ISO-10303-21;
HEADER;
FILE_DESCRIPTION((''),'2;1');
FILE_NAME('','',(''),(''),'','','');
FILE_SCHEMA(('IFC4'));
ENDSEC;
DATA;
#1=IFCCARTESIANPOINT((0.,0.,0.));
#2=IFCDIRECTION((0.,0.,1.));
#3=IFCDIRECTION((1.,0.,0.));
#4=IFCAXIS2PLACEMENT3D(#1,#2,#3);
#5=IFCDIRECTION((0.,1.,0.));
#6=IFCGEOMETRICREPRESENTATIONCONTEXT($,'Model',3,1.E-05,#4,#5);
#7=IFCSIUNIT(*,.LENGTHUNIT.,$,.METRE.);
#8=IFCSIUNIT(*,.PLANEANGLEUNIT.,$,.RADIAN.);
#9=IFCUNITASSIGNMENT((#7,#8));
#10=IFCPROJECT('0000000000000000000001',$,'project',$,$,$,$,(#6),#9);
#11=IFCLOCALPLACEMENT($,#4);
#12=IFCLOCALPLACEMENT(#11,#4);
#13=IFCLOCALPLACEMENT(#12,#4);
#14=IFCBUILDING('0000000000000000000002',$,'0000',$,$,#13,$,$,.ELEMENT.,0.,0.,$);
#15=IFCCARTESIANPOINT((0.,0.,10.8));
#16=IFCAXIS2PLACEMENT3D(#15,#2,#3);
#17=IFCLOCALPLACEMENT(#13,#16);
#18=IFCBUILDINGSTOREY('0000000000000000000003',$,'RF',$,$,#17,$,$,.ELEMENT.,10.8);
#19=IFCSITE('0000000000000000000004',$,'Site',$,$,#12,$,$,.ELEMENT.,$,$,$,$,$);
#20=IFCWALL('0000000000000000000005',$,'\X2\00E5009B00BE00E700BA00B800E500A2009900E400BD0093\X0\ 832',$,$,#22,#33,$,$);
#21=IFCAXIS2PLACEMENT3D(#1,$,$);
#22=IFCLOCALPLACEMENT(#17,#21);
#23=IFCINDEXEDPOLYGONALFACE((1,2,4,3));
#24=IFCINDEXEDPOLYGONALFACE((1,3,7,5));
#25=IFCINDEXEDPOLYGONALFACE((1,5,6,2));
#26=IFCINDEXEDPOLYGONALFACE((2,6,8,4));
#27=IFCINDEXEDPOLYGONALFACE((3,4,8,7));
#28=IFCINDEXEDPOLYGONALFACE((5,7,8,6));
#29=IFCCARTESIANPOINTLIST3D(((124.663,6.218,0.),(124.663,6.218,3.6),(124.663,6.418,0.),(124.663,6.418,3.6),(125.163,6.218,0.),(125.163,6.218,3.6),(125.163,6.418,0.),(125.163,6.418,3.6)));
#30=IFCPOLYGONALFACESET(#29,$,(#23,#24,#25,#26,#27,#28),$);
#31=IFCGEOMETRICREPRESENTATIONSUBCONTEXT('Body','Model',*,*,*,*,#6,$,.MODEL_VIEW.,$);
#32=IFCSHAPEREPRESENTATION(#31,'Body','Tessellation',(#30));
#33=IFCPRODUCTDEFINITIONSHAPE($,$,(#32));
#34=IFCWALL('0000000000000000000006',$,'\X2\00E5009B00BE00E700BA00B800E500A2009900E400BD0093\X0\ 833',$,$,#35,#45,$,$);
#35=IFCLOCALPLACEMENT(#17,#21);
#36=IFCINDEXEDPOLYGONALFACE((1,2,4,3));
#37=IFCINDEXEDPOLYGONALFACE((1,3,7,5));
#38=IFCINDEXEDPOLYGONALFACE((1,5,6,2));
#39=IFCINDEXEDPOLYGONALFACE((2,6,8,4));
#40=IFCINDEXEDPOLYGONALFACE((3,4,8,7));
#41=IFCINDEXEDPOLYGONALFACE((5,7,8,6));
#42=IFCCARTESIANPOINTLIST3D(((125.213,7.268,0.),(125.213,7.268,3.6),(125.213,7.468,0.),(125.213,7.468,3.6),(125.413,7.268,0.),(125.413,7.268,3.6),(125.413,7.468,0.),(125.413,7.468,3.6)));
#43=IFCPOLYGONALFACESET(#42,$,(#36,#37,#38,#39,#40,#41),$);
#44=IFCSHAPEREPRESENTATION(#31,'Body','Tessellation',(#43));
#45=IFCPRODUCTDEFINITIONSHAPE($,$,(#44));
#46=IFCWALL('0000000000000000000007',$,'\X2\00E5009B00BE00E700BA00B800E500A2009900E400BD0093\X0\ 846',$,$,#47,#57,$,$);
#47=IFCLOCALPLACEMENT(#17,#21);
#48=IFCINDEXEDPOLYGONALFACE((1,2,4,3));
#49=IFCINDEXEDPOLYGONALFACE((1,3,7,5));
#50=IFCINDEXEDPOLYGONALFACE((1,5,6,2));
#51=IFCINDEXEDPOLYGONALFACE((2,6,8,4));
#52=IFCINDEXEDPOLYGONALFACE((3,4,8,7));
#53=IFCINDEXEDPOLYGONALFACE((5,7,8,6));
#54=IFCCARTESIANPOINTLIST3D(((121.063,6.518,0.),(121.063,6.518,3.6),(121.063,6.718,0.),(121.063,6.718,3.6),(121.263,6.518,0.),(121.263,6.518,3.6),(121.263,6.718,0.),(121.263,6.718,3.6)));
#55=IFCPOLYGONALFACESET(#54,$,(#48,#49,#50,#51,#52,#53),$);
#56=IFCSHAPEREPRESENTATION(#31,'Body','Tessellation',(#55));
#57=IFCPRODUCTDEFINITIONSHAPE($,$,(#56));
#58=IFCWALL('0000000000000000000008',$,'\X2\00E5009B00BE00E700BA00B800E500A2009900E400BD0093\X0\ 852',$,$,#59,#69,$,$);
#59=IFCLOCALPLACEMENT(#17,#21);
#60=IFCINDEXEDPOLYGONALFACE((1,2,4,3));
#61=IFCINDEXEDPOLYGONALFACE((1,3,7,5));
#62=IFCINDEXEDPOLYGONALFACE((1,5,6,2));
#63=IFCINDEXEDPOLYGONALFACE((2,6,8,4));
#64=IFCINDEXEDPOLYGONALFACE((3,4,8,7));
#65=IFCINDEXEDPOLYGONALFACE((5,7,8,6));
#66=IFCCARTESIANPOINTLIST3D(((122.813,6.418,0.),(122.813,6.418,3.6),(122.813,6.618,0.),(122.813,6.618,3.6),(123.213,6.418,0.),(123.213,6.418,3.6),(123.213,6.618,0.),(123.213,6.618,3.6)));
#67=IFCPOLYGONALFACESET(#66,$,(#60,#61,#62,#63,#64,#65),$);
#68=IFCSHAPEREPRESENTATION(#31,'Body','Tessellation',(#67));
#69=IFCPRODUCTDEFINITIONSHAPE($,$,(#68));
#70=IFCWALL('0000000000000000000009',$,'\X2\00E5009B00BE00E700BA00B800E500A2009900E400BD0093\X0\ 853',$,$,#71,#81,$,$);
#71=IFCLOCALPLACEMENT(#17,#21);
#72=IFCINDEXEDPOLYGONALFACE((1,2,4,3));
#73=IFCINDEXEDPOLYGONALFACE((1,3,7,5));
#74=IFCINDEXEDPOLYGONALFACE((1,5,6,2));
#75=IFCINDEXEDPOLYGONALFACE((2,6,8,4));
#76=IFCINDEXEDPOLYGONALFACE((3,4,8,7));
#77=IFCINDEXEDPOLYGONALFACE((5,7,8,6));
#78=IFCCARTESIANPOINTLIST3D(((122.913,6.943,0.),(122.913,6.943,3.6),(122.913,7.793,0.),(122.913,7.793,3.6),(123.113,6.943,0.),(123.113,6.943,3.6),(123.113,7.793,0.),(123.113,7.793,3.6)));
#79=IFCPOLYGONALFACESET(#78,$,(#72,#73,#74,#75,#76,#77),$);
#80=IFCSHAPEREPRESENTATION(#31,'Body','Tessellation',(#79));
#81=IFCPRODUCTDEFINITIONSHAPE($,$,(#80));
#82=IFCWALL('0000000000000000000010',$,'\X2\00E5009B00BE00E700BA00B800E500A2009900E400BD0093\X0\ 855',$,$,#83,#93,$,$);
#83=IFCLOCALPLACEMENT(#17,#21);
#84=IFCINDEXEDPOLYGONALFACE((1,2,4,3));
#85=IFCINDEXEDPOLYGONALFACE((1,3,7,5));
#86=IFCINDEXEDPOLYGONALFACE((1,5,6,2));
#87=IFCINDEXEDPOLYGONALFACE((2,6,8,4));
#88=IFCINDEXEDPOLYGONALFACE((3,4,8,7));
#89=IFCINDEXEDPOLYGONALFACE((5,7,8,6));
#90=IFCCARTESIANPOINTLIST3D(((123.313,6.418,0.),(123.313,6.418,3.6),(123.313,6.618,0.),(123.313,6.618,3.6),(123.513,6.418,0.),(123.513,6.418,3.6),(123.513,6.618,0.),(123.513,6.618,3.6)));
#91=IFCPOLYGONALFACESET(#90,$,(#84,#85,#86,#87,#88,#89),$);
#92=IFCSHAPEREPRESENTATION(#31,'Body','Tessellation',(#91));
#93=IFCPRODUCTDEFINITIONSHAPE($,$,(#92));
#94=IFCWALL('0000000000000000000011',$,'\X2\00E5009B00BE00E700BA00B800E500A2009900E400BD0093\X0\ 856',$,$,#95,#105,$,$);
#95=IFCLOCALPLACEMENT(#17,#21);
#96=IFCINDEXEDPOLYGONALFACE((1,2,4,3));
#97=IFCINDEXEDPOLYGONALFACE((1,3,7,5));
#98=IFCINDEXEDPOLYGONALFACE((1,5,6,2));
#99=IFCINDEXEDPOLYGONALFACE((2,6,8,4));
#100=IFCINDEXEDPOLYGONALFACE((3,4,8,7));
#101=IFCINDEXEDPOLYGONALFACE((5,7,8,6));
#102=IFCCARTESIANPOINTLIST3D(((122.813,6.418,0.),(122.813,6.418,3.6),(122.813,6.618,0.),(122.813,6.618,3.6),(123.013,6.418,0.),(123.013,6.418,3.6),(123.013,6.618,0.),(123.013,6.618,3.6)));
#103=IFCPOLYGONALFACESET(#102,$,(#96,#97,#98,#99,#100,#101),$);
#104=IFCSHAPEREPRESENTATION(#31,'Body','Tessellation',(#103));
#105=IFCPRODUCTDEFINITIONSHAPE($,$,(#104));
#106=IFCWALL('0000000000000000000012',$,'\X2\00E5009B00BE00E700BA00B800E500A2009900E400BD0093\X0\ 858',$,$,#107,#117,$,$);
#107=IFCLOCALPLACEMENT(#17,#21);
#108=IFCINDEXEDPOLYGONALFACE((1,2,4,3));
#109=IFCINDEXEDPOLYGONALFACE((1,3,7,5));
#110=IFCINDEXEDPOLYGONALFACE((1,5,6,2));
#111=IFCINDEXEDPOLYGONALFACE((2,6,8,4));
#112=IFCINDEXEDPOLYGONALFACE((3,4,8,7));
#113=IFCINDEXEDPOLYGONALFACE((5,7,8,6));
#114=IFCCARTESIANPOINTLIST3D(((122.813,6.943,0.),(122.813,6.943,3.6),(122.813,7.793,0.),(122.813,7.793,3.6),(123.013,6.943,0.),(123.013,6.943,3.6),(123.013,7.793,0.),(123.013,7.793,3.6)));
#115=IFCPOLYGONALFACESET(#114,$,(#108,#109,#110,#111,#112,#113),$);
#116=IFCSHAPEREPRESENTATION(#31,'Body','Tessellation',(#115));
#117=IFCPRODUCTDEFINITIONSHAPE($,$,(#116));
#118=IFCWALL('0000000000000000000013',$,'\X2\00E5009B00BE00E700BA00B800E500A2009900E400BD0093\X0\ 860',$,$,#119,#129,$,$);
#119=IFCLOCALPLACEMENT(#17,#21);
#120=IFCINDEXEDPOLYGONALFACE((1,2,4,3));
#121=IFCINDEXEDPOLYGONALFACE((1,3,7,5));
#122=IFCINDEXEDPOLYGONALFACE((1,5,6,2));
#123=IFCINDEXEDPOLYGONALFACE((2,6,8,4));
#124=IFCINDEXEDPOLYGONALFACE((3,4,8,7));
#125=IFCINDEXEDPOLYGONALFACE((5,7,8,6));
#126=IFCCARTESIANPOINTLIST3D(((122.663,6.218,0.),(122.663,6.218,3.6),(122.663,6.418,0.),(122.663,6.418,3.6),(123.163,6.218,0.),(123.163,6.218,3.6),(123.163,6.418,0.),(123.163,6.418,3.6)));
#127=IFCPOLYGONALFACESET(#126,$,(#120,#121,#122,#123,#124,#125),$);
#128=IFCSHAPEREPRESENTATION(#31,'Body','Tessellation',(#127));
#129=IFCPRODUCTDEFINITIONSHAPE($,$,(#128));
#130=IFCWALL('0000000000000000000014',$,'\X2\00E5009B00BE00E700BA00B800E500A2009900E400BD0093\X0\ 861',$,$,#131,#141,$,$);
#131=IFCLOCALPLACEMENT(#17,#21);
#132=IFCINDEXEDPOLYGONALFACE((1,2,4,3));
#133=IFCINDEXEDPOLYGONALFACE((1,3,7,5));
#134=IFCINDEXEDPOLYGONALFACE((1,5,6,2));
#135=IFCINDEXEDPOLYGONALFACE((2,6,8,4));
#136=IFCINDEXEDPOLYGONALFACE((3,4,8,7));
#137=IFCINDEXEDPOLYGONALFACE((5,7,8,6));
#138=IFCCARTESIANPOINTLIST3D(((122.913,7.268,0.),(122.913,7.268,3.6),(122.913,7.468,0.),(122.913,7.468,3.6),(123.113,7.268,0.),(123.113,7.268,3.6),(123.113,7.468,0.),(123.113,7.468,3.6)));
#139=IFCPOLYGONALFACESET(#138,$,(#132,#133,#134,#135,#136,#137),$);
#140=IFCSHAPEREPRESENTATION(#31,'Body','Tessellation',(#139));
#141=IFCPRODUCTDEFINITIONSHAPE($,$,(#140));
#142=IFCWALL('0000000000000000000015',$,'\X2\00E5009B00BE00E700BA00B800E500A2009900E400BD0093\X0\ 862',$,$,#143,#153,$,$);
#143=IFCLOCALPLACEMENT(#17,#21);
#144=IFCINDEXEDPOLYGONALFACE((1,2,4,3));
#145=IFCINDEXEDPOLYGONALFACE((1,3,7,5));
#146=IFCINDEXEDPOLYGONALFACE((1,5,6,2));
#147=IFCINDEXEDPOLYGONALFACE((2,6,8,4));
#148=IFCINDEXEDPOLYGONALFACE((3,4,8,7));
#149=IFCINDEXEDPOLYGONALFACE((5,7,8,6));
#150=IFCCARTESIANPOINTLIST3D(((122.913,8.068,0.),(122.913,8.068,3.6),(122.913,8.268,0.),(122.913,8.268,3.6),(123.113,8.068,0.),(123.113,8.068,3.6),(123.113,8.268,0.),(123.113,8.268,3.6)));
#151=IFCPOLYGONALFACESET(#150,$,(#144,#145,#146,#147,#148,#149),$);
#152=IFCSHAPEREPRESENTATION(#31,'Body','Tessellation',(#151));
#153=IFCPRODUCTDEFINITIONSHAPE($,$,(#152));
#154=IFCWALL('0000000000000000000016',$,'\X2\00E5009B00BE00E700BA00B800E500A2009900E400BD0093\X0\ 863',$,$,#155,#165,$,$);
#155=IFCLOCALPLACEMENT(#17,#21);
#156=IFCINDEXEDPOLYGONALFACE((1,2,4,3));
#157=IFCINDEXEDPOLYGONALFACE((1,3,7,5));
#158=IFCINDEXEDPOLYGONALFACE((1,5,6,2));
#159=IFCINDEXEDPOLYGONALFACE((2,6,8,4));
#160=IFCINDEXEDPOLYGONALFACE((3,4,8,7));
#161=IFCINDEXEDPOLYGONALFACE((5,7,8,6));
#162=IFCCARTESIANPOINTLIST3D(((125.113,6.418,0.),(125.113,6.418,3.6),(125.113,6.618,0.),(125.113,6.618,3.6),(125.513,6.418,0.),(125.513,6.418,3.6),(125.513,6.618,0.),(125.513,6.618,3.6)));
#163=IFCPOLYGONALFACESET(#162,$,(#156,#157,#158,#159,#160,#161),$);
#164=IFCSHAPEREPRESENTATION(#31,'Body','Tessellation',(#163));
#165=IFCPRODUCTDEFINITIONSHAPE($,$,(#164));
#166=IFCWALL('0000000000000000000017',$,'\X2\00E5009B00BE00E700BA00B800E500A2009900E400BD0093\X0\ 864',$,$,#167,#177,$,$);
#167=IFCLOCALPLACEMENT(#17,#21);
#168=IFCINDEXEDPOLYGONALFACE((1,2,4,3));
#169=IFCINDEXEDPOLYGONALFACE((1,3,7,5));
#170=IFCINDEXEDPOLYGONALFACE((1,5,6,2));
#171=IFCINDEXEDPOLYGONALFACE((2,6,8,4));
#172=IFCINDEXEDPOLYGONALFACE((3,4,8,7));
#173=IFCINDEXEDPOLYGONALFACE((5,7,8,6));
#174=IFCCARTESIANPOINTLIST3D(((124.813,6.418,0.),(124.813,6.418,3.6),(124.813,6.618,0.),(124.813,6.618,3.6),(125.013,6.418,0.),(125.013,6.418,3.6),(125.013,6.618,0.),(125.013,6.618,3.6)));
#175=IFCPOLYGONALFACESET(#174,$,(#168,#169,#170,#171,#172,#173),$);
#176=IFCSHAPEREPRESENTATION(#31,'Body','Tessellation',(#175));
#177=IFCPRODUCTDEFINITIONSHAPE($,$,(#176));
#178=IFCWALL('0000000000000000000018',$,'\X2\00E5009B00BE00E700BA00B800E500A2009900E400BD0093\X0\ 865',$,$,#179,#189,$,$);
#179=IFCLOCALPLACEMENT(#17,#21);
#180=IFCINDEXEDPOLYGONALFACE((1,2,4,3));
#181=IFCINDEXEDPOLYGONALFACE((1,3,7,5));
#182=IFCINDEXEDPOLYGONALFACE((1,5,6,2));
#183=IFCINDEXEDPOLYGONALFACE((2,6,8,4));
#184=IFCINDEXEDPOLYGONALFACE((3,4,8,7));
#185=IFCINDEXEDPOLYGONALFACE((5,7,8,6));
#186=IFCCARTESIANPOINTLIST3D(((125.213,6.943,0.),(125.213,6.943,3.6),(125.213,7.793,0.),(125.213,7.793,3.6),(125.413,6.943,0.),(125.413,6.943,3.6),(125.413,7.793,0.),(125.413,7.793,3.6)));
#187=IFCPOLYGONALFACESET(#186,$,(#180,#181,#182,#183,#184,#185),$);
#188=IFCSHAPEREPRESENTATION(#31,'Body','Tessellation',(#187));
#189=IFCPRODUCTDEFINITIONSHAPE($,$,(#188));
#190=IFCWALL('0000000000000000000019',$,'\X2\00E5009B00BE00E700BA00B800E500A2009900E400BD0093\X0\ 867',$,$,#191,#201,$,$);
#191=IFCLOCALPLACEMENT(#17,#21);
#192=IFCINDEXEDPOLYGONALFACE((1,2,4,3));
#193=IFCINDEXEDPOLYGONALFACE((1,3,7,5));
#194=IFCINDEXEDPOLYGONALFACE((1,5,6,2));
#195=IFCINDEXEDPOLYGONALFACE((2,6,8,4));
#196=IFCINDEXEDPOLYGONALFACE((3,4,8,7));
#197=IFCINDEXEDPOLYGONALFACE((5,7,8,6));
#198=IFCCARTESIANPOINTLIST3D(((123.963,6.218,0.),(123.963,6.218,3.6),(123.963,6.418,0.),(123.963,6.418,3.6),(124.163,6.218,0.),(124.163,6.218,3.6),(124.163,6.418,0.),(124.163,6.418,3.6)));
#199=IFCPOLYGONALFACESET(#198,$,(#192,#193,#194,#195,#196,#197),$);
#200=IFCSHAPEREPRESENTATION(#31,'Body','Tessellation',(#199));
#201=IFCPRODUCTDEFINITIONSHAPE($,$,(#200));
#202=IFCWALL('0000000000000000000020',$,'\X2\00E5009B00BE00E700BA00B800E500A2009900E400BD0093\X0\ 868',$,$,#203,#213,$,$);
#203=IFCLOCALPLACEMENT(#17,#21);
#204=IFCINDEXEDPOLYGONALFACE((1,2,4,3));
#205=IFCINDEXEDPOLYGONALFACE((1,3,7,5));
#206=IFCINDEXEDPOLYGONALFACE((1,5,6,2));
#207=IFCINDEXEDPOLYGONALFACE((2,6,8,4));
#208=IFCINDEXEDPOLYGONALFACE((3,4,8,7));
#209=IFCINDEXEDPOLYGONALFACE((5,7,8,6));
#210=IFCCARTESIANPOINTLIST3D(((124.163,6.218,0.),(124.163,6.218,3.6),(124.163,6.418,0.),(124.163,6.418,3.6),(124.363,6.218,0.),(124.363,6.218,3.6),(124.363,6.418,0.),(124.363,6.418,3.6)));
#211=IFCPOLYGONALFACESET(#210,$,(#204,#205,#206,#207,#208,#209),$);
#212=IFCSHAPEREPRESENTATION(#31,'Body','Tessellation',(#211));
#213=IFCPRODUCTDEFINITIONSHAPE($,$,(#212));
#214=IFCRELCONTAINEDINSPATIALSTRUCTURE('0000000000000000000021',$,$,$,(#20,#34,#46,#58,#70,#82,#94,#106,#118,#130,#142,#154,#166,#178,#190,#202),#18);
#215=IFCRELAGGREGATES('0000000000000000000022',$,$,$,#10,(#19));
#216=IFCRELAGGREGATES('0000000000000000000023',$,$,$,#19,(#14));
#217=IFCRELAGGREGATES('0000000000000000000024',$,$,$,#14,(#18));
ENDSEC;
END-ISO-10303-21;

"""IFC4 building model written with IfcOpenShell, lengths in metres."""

from ifc_helpers import new_model, si_unit, direction, frame, frame_2d, origin_with_axes, place, context, subcontext, project, spatial, rectangle, extrude, element, save


model = new_model("IFC4")

# Units and contexts
model_context = context("Model", 3, precision=1e-05, world=origin_with_axes(), true_north=direction((0.0, 1.0, 0.0)))
body_context = subcontext(model_context, "Body", "Model", "MODEL_VIEW")
ifc_project = project(units=[si_unit("LENGTHUNIT", "METRE"), si_unit("PLANEANGLEUNIT", "RADIAN")], contexts=[model_context])

# Site, building, storey
placement = place(None, origin_with_axes())
site_placement = place(placement, origin_with_axes())
site = spatial("IfcSite", under=ifc_project, at=site_placement, Name="Site", CompositionType="ELEMENT")
building_placement = place(site_placement, origin_with_axes())
building = spatial("IfcBuilding", under=site, at=building_placement, Name="0000", CompositionType="ELEMENT", ElevationOfRefHeight=0.0, ElevationOfTerrain=0.0)
storey_placement = place(building_placement, frame((0.0, 0.0, 10.8), z_axis=(0.0, 0.0, 1.0), x_axis=(1.0, 0.0, 0.0)))
storey = spatial("IfcBuildingStorey", under=building, at=storey_placement, Name="RF", CompositionType="ELEMENT", Elevation=10.8)

# Walls
wall_1_placement = place(storey_placement, frame((124.913, 6.318, 0.0), z_axis=(0.0, 0.0, 1.0), x_axis=(1.0, 0.0, 0.0)))
element("IfcWall", 1, at=wall_1_placement, inside=storey, Name="å\u009b¾çº¸å¢\u0099ä½\u0093 832", context=body_context, shape_type="SweptSolid", body=[
    extrude(rectangle(XDim=0.5, YDim=0.2, at=frame_2d((0.0, 0.0), x_axis=(1.0, 0.0, 0.0))), frame((0.0, 0.0, 0.0), z_axis=(0.0, 0.0, 1.0)), (0.0, 0.0, 1.0), 3.6),
])
for number, where, z_axis, x_axis, name in (
    (2, (125.313, 7.368, 0.0), (0.0, 0.0, 1.0), (1.0, 0.0, 0.0), "å\u009b¾çº¸å¢\u0099ä½\u0093 833"),
    (3, (121.163, 6.618, 0.0), (0.0, 0.0, 1.0), (0.0, -1.0, 0.0), "å\u009b¾çº¸å¢\u0099ä½\u0093 846"),
):
    element("IfcWall", number, at=place(storey_placement, frame(where, z_axis=z_axis, x_axis=x_axis)), inside=storey, Name=name, context=body_context, shape_type="SweptSolid", body=[
        extrude(rectangle(XDim=0.2, YDim=0.2, at=frame_2d((0.0, 0.0), x_axis=(1.0, 0.0, 0.0))), frame((0.0, 0.0, 0.0), z_axis=(0.0, 0.0, 1.0)), (0.0, 0.0, 1.0), 3.6),
    ])
wall_2_placement = place(storey_placement, frame((123.013, 6.518, 0.0), z_axis=(0.0, 0.0, 1.0), x_axis=(1.0, 0.0, 0.0)))
element("IfcWall", 4, at=wall_2_placement, inside=storey, Name="å\u009b¾çº¸å¢\u0099ä½\u0093 852", context=body_context, shape_type="SweptSolid", body=[
    extrude(rectangle(XDim=0.4, YDim=0.2, at=frame_2d((0.0, 0.0), x_axis=(1.0, 0.0, 0.0))), frame((0.0, 0.0, 0.0), z_axis=(0.0, 0.0, 1.0)), (0.0, 0.0, 1.0), 3.6),
])
wall_3_placement = place(storey_placement, frame((123.013, 7.368, 0.0), z_axis=(0.0, 0.0, 1.0), x_axis=(0.0, -1.0, 0.0)))
element("IfcWall", 5, at=wall_3_placement, inside=storey, Name="å\u009b¾çº¸å¢\u0099ä½\u0093 853", context=body_context, shape_type="SweptSolid", body=[
    extrude(rectangle(XDim=0.85, YDim=0.2, at=frame_2d((0.0, 0.0), x_axis=(1.0, 0.0, 0.0))), frame((0.0, 0.0, 0.0), z_axis=(0.0, 0.0, 1.0)), (0.0, 0.0, 1.0), 3.6),
])
for number, where, z_axis, x_axis, name in (
    (6, (123.413, 6.518, 0.0), (0.0, 0.0, 1.0), (0.0, -1.0, 0.0), "å\u009b¾çº¸å¢\u0099ä½\u0093 855"),
    (7, (122.913, 6.518, 0.0), (0.0, 0.0, 1.0), (0.0, -1.0, 0.0), "å\u009b¾çº¸å¢\u0099ä½\u0093 856"),
):
    element("IfcWall", number, at=place(storey_placement, frame(where, z_axis=z_axis, x_axis=x_axis)), inside=storey, Name=name, context=body_context, shape_type="SweptSolid", body=[
        extrude(rectangle(XDim=0.2, YDim=0.2, at=frame_2d((0.0, 0.0), x_axis=(1.0, 0.0, 0.0))), frame((0.0, 0.0, 0.0), z_axis=(0.0, 0.0, 1.0)), (0.0, 0.0, 1.0), 3.6),
    ])
wall_4_placement = place(storey_placement, frame((122.913, 7.368, 0.0), z_axis=(0.0, 0.0, 1.0), x_axis=(0.0, -1.0, 0.0)))
element("IfcWall", 8, at=wall_4_placement, inside=storey, Name="å\u009b¾çº¸å¢\u0099ä½\u0093 858", context=body_context, shape_type="SweptSolid", body=[
    extrude(rectangle(XDim=0.85, YDim=0.2, at=frame_2d((0.0, 0.0), x_axis=(1.0, 0.0, 0.0))), frame((0.0, 0.0, 0.0), z_axis=(0.0, 0.0, 1.0)), (0.0, 0.0, 1.0), 3.6),
])
wall_5_placement = place(storey_placement, frame((122.913, 6.318, 0.0), z_axis=(0.0, 0.0, 1.0), x_axis=(1.0, 0.0, 0.0)))
element("IfcWall", 9, at=wall_5_placement, inside=storey, Name="å\u009b¾çº¸å¢\u0099ä½\u0093 860", context=body_context, shape_type="SweptSolid", body=[
    extrude(rectangle(XDim=0.5, YDim=0.2, at=frame_2d((0.0, 0.0), x_axis=(1.0, 0.0, 0.0))), frame((0.0, 0.0, 0.0), z_axis=(0.0, 0.0, 1.0)), (0.0, 0.0, 1.0), 3.6),
])
for number, where, z_axis, x_axis, name in (
    (10, (123.013, 7.368, 0.0), (0.0, 0.0, 1.0), (-1.0, 0.0, 0.0), "å\u009b¾çº¸å¢\u0099ä½\u0093 861"),
    (11, (123.013, 8.168, 0.0), (0.0, 0.0, 1.0), (-1.0, 0.0, 0.0), "å\u009b¾çº¸å¢\u0099ä½\u0093 862"),
):
    element("IfcWall", number, at=place(storey_placement, frame(where, z_axis=z_axis, x_axis=x_axis)), inside=storey, Name=name, context=body_context, shape_type="SweptSolid", body=[
        extrude(rectangle(XDim=0.2, YDim=0.2, at=frame_2d((0.0, 0.0), x_axis=(1.0, 0.0, 0.0))), frame((0.0, 0.0, 0.0), z_axis=(0.0, 0.0, 1.0)), (0.0, 0.0, 1.0), 3.6),
    ])
wall_6_placement = place(storey_placement, frame((125.313, 6.518, 0.0), z_axis=(0.0, 0.0, 1.0), x_axis=(-1.0, 0.0, 0.0)))
element("IfcWall", 12, at=wall_6_placement, inside=storey, Name="å\u009b¾çº¸å¢\u0099ä½\u0093 863", context=body_context, shape_type="SweptSolid", body=[
    extrude(rectangle(XDim=0.4, YDim=0.2, at=frame_2d((0.0, 0.0), x_axis=(1.0, 0.0, 0.0))), frame((0.0, 0.0, 0.0), z_axis=(0.0, 0.0, 1.0)), (0.0, 0.0, 1.0), 3.6),
])
wall_7_placement = place(storey_placement, frame((124.913, 6.518, 0.0), z_axis=(0.0, 0.0, 1.0), x_axis=(0.0, -1.0, 0.0)))
element("IfcWall", 13, at=wall_7_placement, inside=storey, Name="å\u009b¾çº¸å¢\u0099ä½\u0093 864", context=body_context, shape_type="SweptSolid", body=[
    extrude(rectangle(XDim=0.2, YDim=0.2, at=frame_2d((0.0, 0.0), x_axis=(1.0, 0.0, 0.0))), frame((0.0, 0.0, 0.0), z_axis=(0.0, 0.0, 1.0)), (0.0, 0.0, 1.0), 3.6),
])
wall_8_placement = place(storey_placement, frame((125.313, 7.368, 0.0), z_axis=(0.0, 0.0, 1.0), x_axis=(0.0, -1.0, 0.0)))
element("IfcWall", 14, at=wall_8_placement, inside=storey, Name="å\u009b¾çº¸å¢\u0099ä½\u0093 865", context=body_context, shape_type="SweptSolid", body=[
    extrude(rectangle(XDim=0.85, YDim=0.2, at=frame_2d((0.0, 0.0), x_axis=(1.0, 0.0, 0.0))), frame((0.0, 0.0, 0.0), z_axis=(0.0, 0.0, 1.0)), (0.0, 0.0, 1.0), 3.6),
])
for number, where, z_axis, x_axis, name in (
    (15, (124.063, 6.318, 0.0), (0.0, 0.0, 1.0), (1.0, 0.0, 0.0), "å\u009b¾çº¸å¢\u0099ä½\u0093 867"),
    (16, (124.263, 6.318, 0.0), (0.0, 0.0, 1.0), (1.0, 0.0, 0.0), "å\u009b¾çº¸å¢\u0099ä½\u0093 868"),
):
    element("IfcWall", number, at=place(storey_placement, frame(where, z_axis=z_axis, x_axis=x_axis)), inside=storey, Name=name, context=body_context, shape_type="SweptSolid", body=[
        extrude(rectangle(XDim=0.2, YDim=0.2, at=frame_2d((0.0, 0.0), x_axis=(1.0, 0.0, 0.0))), frame((0.0, 0.0, 0.0), z_axis=(0.0, 0.0, 1.0)), (0.0, 0.0, 1.0), 3.6),
    ])

save(model, "model.ifc")
